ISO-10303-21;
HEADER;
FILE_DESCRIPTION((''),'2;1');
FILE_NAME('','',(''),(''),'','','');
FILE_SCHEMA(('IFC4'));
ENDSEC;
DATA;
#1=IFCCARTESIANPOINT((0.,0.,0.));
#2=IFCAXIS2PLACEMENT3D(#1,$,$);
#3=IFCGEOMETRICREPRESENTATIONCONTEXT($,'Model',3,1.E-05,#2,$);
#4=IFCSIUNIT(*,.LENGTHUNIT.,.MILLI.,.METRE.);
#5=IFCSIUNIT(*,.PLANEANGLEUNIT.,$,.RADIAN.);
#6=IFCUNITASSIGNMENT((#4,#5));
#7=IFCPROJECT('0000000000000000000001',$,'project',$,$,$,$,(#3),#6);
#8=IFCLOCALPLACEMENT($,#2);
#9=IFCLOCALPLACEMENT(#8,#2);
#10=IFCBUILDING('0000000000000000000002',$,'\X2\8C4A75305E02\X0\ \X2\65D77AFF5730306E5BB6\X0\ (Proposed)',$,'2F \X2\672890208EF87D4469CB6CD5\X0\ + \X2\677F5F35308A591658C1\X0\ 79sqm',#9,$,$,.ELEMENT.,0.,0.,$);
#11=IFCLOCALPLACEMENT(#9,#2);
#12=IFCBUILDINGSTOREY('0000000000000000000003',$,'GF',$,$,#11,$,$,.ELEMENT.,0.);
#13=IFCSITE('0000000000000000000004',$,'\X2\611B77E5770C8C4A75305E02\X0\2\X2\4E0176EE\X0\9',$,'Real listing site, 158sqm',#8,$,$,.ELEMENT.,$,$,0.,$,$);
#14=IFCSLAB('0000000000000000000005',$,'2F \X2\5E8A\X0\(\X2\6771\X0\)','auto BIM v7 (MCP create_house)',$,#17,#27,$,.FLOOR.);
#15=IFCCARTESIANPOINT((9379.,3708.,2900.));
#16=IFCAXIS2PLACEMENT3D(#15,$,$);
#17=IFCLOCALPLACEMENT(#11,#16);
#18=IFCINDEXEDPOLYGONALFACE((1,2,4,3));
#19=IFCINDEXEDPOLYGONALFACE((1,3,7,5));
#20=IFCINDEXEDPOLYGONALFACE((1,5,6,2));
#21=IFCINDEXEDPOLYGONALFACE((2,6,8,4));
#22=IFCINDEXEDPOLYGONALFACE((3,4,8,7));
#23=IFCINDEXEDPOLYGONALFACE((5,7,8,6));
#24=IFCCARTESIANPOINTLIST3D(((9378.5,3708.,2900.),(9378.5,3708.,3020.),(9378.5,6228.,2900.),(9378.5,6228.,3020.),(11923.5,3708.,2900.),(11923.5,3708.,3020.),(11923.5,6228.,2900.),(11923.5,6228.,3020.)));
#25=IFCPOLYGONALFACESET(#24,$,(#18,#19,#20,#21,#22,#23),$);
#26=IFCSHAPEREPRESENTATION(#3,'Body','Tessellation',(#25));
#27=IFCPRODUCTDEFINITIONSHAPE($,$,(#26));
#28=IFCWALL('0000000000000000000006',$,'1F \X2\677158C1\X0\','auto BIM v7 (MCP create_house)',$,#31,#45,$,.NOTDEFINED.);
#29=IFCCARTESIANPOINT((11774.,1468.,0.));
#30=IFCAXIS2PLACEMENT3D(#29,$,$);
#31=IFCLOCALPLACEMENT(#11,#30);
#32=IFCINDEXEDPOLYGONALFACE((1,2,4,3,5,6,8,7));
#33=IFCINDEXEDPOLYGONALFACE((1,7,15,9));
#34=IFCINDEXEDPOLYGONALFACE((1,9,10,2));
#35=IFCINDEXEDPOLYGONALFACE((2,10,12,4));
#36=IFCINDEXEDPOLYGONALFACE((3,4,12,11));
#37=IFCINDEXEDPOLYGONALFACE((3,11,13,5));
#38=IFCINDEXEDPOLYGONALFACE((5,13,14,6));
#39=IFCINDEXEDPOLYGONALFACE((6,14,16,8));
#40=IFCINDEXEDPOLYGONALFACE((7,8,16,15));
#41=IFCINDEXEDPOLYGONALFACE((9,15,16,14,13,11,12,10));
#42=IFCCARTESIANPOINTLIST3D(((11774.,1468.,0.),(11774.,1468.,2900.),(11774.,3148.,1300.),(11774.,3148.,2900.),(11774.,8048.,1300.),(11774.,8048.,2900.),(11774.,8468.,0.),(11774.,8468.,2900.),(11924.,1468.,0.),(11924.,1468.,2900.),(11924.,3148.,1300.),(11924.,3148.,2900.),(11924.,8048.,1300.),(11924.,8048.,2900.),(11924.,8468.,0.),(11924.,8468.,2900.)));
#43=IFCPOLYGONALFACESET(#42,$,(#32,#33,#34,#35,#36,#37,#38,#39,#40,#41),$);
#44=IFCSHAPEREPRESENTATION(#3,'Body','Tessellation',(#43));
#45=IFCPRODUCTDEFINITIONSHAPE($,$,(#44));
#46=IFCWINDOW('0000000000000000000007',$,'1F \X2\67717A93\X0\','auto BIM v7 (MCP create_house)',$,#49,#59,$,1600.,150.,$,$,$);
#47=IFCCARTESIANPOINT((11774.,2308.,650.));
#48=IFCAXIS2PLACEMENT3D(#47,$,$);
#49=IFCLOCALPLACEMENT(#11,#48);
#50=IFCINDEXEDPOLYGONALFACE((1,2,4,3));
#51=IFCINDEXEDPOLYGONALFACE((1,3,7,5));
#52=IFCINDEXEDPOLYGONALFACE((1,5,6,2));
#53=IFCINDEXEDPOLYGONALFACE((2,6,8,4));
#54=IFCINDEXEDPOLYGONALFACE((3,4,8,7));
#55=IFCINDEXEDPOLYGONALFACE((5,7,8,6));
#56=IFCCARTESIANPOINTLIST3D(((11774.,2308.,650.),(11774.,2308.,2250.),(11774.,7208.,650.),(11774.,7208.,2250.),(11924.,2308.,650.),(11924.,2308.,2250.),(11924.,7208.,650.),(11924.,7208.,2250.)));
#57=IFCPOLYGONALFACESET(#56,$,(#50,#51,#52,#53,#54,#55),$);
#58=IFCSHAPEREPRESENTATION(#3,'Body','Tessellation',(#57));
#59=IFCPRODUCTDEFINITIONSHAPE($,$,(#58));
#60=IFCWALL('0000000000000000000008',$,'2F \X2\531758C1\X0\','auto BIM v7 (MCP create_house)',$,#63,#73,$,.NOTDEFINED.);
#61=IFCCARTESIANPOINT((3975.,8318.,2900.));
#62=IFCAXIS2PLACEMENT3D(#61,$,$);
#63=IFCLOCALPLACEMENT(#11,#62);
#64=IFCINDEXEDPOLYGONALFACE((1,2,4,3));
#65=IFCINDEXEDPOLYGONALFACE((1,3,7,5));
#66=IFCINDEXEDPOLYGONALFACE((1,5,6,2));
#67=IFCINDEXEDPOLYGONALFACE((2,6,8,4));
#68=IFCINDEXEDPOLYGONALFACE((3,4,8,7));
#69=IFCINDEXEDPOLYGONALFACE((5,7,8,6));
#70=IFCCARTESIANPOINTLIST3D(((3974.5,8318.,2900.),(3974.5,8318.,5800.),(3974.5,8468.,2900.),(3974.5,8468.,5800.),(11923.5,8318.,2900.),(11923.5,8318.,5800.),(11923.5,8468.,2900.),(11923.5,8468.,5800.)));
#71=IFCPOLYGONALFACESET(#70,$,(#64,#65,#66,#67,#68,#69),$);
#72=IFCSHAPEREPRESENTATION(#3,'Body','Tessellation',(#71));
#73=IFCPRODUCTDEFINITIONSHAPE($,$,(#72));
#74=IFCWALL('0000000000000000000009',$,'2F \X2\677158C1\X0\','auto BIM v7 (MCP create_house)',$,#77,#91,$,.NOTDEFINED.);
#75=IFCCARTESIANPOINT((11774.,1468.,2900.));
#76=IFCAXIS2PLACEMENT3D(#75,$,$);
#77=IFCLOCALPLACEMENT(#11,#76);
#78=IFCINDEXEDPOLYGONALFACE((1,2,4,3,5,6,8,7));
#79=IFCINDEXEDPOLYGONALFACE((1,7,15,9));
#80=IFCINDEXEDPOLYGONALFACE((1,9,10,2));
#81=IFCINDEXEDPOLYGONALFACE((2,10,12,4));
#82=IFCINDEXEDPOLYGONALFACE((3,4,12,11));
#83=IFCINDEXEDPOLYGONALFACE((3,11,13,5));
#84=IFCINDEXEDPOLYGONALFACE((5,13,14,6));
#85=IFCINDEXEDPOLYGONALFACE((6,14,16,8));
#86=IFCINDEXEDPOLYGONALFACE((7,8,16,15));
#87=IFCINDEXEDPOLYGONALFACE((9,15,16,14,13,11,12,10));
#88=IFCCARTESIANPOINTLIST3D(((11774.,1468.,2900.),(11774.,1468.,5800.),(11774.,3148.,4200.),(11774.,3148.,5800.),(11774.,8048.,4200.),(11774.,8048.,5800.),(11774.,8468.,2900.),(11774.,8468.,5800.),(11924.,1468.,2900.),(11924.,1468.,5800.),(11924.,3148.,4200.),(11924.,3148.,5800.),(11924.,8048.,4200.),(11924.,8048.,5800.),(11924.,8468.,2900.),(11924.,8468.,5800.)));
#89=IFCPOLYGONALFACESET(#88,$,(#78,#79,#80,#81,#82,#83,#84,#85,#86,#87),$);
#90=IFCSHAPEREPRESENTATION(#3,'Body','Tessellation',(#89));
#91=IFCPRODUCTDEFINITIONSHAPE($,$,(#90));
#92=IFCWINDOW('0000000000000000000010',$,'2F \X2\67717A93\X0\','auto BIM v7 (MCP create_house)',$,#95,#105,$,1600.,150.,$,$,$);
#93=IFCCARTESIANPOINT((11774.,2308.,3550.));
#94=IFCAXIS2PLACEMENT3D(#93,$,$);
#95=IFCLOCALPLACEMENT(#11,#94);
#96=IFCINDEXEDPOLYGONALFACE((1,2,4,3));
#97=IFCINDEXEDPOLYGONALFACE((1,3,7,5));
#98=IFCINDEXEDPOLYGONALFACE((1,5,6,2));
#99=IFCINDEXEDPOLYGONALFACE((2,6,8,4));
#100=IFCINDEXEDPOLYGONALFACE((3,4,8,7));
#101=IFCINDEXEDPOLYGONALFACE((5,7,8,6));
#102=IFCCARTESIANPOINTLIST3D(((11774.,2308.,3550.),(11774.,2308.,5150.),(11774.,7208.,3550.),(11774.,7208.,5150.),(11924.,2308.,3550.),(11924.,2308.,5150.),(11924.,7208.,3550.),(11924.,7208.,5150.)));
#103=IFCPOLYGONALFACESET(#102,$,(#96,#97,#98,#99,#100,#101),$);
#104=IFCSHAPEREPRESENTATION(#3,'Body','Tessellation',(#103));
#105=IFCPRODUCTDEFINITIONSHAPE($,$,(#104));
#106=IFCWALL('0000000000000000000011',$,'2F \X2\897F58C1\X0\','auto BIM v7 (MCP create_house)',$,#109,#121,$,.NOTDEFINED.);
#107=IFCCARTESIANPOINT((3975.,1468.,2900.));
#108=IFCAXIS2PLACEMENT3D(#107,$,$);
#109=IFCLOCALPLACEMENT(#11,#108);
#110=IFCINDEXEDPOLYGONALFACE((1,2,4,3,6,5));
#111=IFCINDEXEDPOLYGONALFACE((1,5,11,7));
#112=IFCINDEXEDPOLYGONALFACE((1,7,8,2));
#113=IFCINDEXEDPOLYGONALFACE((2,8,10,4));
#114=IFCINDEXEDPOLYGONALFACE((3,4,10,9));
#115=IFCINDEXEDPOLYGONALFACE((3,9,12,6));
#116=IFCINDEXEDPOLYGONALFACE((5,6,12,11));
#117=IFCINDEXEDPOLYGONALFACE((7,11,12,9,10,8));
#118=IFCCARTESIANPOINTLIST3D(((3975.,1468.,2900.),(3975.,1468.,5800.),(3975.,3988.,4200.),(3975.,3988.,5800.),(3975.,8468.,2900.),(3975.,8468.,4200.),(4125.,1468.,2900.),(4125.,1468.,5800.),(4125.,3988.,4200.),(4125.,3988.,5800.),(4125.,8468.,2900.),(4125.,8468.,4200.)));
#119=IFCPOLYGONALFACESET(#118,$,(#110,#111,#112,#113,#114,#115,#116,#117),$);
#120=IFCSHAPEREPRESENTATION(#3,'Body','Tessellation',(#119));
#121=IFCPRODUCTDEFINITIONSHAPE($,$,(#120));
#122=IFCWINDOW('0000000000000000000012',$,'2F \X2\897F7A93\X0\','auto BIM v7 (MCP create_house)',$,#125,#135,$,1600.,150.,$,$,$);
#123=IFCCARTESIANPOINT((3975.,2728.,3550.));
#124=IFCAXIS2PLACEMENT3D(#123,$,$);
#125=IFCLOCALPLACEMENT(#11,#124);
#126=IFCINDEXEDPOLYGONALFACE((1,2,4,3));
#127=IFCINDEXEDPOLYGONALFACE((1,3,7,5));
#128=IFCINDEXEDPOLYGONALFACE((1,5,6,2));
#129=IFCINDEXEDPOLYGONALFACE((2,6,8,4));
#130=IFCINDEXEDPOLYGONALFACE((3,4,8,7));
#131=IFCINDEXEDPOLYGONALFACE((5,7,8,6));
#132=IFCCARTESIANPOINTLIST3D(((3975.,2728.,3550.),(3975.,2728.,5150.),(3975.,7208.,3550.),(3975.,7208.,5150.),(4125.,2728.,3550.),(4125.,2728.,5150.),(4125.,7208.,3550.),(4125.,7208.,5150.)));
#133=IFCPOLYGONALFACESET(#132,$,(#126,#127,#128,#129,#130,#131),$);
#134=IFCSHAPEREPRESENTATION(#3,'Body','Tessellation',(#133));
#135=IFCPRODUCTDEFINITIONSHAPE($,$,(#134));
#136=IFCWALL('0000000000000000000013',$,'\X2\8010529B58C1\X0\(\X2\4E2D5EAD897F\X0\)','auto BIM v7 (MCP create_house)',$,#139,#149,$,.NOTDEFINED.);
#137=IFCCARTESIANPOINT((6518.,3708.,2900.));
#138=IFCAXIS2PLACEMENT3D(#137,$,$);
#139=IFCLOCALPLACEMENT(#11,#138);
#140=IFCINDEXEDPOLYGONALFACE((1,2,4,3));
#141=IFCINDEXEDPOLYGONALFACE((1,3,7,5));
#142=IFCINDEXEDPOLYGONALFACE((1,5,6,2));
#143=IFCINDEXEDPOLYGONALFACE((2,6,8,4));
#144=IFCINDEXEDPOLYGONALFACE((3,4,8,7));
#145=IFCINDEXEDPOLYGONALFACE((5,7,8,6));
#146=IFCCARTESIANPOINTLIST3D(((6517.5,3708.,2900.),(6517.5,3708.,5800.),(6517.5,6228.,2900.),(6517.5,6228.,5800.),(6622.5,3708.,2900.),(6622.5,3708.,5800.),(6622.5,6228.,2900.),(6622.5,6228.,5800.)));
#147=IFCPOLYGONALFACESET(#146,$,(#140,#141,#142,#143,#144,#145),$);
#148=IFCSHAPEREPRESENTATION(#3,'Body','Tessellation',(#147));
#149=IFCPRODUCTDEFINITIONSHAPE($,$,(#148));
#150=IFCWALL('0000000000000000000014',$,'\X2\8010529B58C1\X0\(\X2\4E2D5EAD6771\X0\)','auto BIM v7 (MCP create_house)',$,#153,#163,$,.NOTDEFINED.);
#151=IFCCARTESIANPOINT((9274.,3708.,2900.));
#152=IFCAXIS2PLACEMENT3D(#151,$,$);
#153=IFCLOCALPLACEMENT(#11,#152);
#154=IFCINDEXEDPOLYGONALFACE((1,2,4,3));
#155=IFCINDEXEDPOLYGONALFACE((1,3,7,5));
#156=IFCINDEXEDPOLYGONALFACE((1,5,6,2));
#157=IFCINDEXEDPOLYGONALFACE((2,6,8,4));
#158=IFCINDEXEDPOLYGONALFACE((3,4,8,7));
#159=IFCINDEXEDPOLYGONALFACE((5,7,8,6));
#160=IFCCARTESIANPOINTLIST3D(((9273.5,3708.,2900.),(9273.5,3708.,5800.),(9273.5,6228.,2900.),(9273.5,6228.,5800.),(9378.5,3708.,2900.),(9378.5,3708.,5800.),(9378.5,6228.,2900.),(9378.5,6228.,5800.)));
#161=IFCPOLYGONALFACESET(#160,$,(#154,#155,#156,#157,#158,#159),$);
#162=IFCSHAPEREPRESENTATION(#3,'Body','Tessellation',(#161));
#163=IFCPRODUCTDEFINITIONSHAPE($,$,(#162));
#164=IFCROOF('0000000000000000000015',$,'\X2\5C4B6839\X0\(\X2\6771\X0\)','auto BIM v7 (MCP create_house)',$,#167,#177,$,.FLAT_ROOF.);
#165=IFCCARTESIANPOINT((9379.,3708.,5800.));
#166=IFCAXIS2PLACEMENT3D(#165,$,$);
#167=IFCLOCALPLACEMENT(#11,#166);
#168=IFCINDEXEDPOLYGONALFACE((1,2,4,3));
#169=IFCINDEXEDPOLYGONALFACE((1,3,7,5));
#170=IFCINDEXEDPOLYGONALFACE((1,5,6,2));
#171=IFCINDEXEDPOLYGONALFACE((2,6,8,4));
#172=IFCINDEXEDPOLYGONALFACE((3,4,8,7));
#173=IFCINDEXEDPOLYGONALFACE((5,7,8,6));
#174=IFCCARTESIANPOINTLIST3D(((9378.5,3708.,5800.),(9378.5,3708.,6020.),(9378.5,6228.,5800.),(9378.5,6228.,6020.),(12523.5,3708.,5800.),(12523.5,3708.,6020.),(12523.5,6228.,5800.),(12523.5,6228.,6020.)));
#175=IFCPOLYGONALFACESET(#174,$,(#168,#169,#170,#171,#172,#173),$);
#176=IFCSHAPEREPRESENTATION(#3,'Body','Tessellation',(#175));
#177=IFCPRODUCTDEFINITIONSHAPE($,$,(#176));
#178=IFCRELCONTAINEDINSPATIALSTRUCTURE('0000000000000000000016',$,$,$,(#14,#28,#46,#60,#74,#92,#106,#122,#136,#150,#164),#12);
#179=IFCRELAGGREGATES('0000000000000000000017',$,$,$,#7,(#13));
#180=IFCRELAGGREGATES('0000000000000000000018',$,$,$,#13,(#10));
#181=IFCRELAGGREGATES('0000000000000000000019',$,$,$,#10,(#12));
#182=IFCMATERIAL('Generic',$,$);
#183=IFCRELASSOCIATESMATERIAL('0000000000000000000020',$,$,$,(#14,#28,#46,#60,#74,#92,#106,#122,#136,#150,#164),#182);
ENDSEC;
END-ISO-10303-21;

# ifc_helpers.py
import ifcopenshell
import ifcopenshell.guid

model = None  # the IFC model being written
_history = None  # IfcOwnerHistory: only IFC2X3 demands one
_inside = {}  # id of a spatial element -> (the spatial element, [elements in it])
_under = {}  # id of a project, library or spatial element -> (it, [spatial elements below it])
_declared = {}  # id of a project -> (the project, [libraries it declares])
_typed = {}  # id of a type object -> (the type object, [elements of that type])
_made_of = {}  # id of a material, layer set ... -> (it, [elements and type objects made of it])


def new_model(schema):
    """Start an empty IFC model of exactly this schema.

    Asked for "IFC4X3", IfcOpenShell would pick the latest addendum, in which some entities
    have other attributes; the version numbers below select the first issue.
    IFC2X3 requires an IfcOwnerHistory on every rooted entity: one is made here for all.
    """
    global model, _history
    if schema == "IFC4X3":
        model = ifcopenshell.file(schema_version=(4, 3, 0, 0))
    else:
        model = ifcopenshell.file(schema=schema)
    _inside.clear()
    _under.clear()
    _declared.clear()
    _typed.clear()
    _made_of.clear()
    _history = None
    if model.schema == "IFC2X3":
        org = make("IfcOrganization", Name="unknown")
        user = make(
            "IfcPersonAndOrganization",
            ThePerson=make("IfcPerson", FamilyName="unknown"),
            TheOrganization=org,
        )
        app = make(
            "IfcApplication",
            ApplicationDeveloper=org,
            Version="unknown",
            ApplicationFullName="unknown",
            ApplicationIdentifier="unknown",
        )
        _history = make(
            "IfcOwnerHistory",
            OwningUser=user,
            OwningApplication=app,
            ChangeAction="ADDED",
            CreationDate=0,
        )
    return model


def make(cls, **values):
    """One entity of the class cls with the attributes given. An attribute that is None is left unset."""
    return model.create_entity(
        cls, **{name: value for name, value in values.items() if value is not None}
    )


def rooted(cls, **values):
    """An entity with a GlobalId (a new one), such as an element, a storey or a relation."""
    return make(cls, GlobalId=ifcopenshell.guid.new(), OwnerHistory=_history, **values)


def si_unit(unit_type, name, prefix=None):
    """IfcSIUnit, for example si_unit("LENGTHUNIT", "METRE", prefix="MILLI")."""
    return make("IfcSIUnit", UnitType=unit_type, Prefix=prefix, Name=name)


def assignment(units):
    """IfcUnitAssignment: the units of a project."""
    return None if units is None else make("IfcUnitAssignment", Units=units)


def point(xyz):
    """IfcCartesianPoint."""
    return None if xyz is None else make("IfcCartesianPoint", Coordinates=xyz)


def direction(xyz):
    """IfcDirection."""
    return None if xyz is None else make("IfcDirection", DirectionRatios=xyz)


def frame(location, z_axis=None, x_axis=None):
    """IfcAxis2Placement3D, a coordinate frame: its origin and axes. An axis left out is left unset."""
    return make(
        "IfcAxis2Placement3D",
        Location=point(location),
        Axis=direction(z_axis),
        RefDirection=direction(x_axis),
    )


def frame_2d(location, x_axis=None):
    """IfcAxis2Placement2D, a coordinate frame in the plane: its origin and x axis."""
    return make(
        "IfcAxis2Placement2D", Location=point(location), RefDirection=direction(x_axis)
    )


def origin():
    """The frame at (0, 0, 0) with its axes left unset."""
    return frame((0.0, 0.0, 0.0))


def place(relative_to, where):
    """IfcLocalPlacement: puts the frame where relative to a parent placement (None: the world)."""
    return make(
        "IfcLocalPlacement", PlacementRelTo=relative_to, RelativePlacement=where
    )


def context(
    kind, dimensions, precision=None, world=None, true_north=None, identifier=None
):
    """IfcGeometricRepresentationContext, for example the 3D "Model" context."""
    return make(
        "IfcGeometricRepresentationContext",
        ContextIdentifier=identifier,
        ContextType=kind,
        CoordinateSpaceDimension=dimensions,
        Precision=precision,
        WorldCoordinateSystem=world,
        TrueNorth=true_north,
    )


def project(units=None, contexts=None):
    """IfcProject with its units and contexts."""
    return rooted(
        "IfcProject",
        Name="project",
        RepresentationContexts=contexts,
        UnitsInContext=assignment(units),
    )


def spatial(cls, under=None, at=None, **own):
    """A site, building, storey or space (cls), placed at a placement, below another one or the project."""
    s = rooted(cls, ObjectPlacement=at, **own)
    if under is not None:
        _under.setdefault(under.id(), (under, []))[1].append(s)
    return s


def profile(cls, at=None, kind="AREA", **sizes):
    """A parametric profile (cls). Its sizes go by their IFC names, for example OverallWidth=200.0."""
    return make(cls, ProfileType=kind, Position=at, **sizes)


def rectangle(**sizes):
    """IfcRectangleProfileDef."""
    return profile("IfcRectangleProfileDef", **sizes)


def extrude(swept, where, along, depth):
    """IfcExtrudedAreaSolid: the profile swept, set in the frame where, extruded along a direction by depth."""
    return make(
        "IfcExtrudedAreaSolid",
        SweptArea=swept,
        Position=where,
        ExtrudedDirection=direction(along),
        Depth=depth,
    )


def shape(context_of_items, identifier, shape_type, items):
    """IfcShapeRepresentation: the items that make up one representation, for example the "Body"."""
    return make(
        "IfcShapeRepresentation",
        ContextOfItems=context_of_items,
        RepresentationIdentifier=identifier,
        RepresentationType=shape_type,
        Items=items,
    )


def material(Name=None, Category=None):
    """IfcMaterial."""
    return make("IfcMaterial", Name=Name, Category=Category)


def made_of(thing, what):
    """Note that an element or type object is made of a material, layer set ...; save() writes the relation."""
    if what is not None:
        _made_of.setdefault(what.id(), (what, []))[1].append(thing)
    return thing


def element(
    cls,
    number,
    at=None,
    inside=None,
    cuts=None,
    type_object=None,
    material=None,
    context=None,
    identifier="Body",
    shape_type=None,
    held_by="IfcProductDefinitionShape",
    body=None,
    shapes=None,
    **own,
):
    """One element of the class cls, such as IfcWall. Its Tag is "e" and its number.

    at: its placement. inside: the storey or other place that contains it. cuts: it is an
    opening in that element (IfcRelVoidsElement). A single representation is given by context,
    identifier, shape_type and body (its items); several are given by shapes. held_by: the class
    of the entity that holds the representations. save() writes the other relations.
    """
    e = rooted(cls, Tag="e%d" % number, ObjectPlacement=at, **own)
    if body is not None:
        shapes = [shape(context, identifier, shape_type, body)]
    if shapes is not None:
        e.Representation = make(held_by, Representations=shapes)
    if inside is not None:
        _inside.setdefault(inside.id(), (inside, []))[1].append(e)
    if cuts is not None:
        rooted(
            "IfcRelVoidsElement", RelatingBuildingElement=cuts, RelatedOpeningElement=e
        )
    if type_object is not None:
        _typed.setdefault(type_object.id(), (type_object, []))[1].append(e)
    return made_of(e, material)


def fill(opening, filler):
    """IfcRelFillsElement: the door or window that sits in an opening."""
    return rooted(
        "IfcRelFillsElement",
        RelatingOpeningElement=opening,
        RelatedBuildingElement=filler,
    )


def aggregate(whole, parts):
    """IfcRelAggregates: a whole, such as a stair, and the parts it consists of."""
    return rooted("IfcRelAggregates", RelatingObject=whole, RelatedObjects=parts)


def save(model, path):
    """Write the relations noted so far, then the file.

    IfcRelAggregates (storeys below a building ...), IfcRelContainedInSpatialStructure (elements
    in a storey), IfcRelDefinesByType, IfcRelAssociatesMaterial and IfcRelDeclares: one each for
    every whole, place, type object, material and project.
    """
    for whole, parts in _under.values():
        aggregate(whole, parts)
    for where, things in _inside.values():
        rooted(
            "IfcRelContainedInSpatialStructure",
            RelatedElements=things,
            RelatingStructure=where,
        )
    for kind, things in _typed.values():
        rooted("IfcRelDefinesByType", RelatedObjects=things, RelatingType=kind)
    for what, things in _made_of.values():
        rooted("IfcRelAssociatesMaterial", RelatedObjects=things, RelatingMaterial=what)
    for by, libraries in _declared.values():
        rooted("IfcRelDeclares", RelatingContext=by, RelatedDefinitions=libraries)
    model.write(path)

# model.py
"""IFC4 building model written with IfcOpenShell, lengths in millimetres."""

from ifc_helpers import new_model, si_unit, frame, frame_2d, origin, place, context, project, spatial, rectangle, extrude, material, element, fill, save


model = new_model("IFC4")

# Units and contexts
model_context = context("Model", 3, precision=1e-05, world=origin())
ifc_project = project(units=[si_unit("LENGTHUNIT", "METRE", prefix="MILLI"), si_unit("PLANEANGLEUNIT", "RADIAN")], contexts=[model_context])

# Site, building, storey
site_placement = place(None, origin())
site = spatial("IfcSite", under=ifc_project, at=site_placement, Name="愛知県豊田市2丁目9", ObjectType="Real listing site, 158sqm", CompositionType="ELEMENT", RefElevation=0.0)
building_placement = place(site_placement, origin())
building = spatial("IfcBuilding", under=site, at=building_placement, Name="豊田市 旗竿地の家 (Proposed)", ObjectType="2F 木造軸組構法 + 板張り外壁 79sqm", CompositionType="ELEMENT", ElevationOfRefHeight=0.0, ElevationOfTerrain=0.0)
storey_placement = place(building_placement, origin())
storey = spatial("IfcBuildingStorey", under=building, at=storey_placement, Name="GF", CompositionType="ELEMENT", Elevation=0.0)

# Slab
ifc_material = material(Name="Generic")
slab_1_placement = place(storey_placement, frame((9379.0, 3708.0, 2900.0)))
element("IfcSlab", 1, at=slab_1_placement, inside=storey, material=ifc_material, Name="2F 床(東)", Description="auto BIM v7 (MCP create_house)", PredefinedType="FLOOR", context=model_context, shape_type="SweptSolid", body=[
    extrude(rectangle(XDim=2545.0, YDim=2520.0, at=frame_2d((1272.0, 1260.0))), frame((9379.0, 3708.0, 2900.0)), (0.0, 0.0, 1.0), 120.0),
])

# Wall, opening, window
wall_1_placement = place(storey_placement, frame((11774.0, 1468.0, 0.0)))
wall_1 = element("IfcWall", 2, at=wall_1_placement, inside=storey, material=ifc_material, Name="1F 東壁", Description="auto BIM v7 (MCP create_house)", PredefinedType="NOTDEFINED", context=model_context, shape_type="SweptSolid", body=[
    extrude(rectangle(XDim=150.0, YDim=7000.0, at=frame_2d((75.0, 3500.0))), frame((11774.0, 1468.0, 0.0)), (0.0, 0.0, 1.0), 2900.0),
])
opening_1_placement = place(storey_placement, frame((11774.0, 2308.0, 650.0)))
opening_1 = element("IfcOpeningElement", 3, at=opening_1_placement, cuts=wall_1, PredefinedType="NOTDEFINED", context=model_context, shape_type="SweptSolid", body=[
    extrude(rectangle(XDim=150.0, YDim=4900.0, at=frame_2d((75.0, 2450.0))), frame((11774.0, 2308.0, 650.0)), (0.0, 0.0, 1.0), 1600.0),
])
window_1_placement = place(storey_placement, frame((11774.0, 2308.0, 650.0)))
window_1 = element("IfcWindow", 4, at=window_1_placement, inside=storey, material=ifc_material, Name="1F 東窓", Description="auto BIM v7 (MCP create_house)", OverallHeight=1600.0, OverallWidth=150.0, context=model_context, shape_type="SweptSolid", body=[
    extrude(rectangle(XDim=150.0, YDim=4900.0, at=frame_2d((75.0, 2450.0))), frame((11774.0, 2308.0, 650.0)), (0.0, 0.0, 1.0), 1600.0),
])
fill(opening_1, window_1)

# Wall
wall_2_placement = place(storey_placement, frame((3975.0, 8318.0, 2900.0)))
element("IfcWall", 5, at=wall_2_placement, inside=storey, material=ifc_material, Name="2F 北壁", Description="auto BIM v7 (MCP create_house)", PredefinedType="NOTDEFINED", context=model_context, shape_type="SweptSolid", body=[
    extrude(rectangle(XDim=7949.0, YDim=150.0, at=frame_2d((3974.0, 75.0))), frame((3975.0, 8318.0, 2900.0)), (0.0, 0.0, 1.0), 2900.0),
])

# Walls, openings, windows
wall_3_placement = place(storey_placement, frame((11774.0, 1468.0, 2900.0)))
wall_3 = element("IfcWall", 6, at=wall_3_placement, inside=storey, material=ifc_material, Name="2F 東壁", Description="auto BIM v7 (MCP create_house)", PredefinedType="NOTDEFINED", context=model_context, shape_type="SweptSolid", body=[
    extrude(rectangle(XDim=150.0, YDim=7000.0, at=frame_2d((75.0, 3500.0))), frame((11774.0, 1468.0, 2900.0)), (0.0, 0.0, 1.0), 2900.0),
])
opening_2_placement = place(storey_placement, frame((11774.0, 2308.0, 3550.0)))
opening_2 = element("IfcOpeningElement", 7, at=opening_2_placement, cuts=wall_3, PredefinedType="NOTDEFINED", context=model_context, shape_type="SweptSolid", body=[
    extrude(rectangle(XDim=150.0, YDim=4900.0, at=frame_2d((75.0, 2450.0))), frame((11774.0, 2308.0, 3550.0)), (0.0, 0.0, 1.0), 1600.0),
])
window_2_placement = place(storey_placement, frame((11774.0, 2308.0, 3550.0)))
window_2 = element("IfcWindow", 8, at=window_2_placement, inside=storey, material=ifc_material, Name="2F 東窓", Description="auto BIM v7 (MCP create_house)", OverallHeight=1600.0, OverallWidth=150.0, context=model_context, shape_type="SweptSolid", body=[
    extrude(rectangle(XDim=150.0, YDim=4900.0, at=frame_2d((75.0, 2450.0))), frame((11774.0, 2308.0, 3550.0)), (0.0, 0.0, 1.0), 1600.0),
])
fill(opening_2, window_2)
wall_4_placement = place(storey_placement, frame((3975.0, 1468.0, 2900.0)))
wall_4 = element("IfcWall", 9, at=wall_4_placement, inside=storey, material=ifc_material, Name="2F 西壁", Description="auto BIM v7 (MCP create_house)", PredefinedType="NOTDEFINED", context=model_context, shape_type="SweptSolid", body=[
    extrude(rectangle(XDim=150.0, YDim=7000.0, at=frame_2d((75.0, 3500.0))), frame((3975.0, 1468.0, 2900.0)), (0.0, 0.0, 1.0), 2900.0),
])
opening_3_placement = place(storey_placement, frame((3975.0, 2728.0, 3550.0)))
opening_3 = element("IfcOpeningElement", 10, at=opening_3_placement, cuts=wall_4, PredefinedType="NOTDEFINED", context=model_context, shape_type="SweptSolid", body=[
    extrude(rectangle(XDim=150.0, YDim=4480.0, at=frame_2d((75.0, 2240.0))), frame((3975.0, 2728.0, 3550.0)), (0.0, 0.0, 1.0), 1600.0),
])
window_3_placement = place(storey_placement, frame((3975.0, 2728.0, 3550.0)))
window_3 = element("IfcWindow", 11, at=window_3_placement, inside=storey, material=ifc_material, Name="2F 西窓", Description="auto BIM v7 (MCP create_house)", OverallHeight=1600.0, OverallWidth=150.0, context=model_context, shape_type="SweptSolid", body=[
    extrude(rectangle(XDim=150.0, YDim=4480.0, at=frame_2d((75.0, 2240.0))), frame((3975.0, 2728.0, 3550.0)), (0.0, 0.0, 1.0), 1600.0),
])
fill(opening_3, window_3)

# Walls
wall_5_placement = place(storey_placement, frame((6518.0, 3708.0, 2900.0)))
element("IfcWall", 12, at=wall_5_placement, inside=storey, material=ifc_material, Name="耐力壁(中庭西)", Description="auto BIM v7 (MCP create_house)", PredefinedType="NOTDEFINED", context=model_context, shape_type="SweptSolid", body=[
    extrude(rectangle(XDim=105.0, YDim=2520.0, at=frame_2d((52.0, 1260.0))), frame((6518.0, 3708.0, 2900.0)), (0.0, 0.0, 1.0), 2900.0),
])
wall_6_placement = place(storey_placement, frame((9274.0, 3708.0, 2900.0)))
element("IfcWall", 13, at=wall_6_placement, inside=storey, material=ifc_material, Name="耐力壁(中庭東)", Description="auto BIM v7 (MCP create_house)", PredefinedType="NOTDEFINED", context=model_context, shape_type="SweptSolid", body=[
    extrude(rectangle(XDim=105.0, YDim=2520.0, at=frame_2d((52.0, 1260.0))), frame((9274.0, 3708.0, 2900.0)), (0.0, 0.0, 1.0), 2900.0),
])

# Roof
for number, where, name in (
    (14, (9379.0, 3708.0, 5800.0), "屋根(東)"),
):
    element("IfcRoof", number, at=place(storey_placement, frame(where)), inside=storey, material=ifc_material, Name=name, Description="auto BIM v7 (MCP create_house)", PredefinedType="FLAT_ROOF", context=model_context, shape_type="SweptSolid", body=[
        extrude(rectangle(XDim=3145.0, YDim=2520.0, at=frame_2d((1572.0, 1260.0))), frame((9379.0, 3708.0, 5800.0)), (0.0, 0.0, 1.0), 220.0),
    ])

save(model, "model.ifc")
